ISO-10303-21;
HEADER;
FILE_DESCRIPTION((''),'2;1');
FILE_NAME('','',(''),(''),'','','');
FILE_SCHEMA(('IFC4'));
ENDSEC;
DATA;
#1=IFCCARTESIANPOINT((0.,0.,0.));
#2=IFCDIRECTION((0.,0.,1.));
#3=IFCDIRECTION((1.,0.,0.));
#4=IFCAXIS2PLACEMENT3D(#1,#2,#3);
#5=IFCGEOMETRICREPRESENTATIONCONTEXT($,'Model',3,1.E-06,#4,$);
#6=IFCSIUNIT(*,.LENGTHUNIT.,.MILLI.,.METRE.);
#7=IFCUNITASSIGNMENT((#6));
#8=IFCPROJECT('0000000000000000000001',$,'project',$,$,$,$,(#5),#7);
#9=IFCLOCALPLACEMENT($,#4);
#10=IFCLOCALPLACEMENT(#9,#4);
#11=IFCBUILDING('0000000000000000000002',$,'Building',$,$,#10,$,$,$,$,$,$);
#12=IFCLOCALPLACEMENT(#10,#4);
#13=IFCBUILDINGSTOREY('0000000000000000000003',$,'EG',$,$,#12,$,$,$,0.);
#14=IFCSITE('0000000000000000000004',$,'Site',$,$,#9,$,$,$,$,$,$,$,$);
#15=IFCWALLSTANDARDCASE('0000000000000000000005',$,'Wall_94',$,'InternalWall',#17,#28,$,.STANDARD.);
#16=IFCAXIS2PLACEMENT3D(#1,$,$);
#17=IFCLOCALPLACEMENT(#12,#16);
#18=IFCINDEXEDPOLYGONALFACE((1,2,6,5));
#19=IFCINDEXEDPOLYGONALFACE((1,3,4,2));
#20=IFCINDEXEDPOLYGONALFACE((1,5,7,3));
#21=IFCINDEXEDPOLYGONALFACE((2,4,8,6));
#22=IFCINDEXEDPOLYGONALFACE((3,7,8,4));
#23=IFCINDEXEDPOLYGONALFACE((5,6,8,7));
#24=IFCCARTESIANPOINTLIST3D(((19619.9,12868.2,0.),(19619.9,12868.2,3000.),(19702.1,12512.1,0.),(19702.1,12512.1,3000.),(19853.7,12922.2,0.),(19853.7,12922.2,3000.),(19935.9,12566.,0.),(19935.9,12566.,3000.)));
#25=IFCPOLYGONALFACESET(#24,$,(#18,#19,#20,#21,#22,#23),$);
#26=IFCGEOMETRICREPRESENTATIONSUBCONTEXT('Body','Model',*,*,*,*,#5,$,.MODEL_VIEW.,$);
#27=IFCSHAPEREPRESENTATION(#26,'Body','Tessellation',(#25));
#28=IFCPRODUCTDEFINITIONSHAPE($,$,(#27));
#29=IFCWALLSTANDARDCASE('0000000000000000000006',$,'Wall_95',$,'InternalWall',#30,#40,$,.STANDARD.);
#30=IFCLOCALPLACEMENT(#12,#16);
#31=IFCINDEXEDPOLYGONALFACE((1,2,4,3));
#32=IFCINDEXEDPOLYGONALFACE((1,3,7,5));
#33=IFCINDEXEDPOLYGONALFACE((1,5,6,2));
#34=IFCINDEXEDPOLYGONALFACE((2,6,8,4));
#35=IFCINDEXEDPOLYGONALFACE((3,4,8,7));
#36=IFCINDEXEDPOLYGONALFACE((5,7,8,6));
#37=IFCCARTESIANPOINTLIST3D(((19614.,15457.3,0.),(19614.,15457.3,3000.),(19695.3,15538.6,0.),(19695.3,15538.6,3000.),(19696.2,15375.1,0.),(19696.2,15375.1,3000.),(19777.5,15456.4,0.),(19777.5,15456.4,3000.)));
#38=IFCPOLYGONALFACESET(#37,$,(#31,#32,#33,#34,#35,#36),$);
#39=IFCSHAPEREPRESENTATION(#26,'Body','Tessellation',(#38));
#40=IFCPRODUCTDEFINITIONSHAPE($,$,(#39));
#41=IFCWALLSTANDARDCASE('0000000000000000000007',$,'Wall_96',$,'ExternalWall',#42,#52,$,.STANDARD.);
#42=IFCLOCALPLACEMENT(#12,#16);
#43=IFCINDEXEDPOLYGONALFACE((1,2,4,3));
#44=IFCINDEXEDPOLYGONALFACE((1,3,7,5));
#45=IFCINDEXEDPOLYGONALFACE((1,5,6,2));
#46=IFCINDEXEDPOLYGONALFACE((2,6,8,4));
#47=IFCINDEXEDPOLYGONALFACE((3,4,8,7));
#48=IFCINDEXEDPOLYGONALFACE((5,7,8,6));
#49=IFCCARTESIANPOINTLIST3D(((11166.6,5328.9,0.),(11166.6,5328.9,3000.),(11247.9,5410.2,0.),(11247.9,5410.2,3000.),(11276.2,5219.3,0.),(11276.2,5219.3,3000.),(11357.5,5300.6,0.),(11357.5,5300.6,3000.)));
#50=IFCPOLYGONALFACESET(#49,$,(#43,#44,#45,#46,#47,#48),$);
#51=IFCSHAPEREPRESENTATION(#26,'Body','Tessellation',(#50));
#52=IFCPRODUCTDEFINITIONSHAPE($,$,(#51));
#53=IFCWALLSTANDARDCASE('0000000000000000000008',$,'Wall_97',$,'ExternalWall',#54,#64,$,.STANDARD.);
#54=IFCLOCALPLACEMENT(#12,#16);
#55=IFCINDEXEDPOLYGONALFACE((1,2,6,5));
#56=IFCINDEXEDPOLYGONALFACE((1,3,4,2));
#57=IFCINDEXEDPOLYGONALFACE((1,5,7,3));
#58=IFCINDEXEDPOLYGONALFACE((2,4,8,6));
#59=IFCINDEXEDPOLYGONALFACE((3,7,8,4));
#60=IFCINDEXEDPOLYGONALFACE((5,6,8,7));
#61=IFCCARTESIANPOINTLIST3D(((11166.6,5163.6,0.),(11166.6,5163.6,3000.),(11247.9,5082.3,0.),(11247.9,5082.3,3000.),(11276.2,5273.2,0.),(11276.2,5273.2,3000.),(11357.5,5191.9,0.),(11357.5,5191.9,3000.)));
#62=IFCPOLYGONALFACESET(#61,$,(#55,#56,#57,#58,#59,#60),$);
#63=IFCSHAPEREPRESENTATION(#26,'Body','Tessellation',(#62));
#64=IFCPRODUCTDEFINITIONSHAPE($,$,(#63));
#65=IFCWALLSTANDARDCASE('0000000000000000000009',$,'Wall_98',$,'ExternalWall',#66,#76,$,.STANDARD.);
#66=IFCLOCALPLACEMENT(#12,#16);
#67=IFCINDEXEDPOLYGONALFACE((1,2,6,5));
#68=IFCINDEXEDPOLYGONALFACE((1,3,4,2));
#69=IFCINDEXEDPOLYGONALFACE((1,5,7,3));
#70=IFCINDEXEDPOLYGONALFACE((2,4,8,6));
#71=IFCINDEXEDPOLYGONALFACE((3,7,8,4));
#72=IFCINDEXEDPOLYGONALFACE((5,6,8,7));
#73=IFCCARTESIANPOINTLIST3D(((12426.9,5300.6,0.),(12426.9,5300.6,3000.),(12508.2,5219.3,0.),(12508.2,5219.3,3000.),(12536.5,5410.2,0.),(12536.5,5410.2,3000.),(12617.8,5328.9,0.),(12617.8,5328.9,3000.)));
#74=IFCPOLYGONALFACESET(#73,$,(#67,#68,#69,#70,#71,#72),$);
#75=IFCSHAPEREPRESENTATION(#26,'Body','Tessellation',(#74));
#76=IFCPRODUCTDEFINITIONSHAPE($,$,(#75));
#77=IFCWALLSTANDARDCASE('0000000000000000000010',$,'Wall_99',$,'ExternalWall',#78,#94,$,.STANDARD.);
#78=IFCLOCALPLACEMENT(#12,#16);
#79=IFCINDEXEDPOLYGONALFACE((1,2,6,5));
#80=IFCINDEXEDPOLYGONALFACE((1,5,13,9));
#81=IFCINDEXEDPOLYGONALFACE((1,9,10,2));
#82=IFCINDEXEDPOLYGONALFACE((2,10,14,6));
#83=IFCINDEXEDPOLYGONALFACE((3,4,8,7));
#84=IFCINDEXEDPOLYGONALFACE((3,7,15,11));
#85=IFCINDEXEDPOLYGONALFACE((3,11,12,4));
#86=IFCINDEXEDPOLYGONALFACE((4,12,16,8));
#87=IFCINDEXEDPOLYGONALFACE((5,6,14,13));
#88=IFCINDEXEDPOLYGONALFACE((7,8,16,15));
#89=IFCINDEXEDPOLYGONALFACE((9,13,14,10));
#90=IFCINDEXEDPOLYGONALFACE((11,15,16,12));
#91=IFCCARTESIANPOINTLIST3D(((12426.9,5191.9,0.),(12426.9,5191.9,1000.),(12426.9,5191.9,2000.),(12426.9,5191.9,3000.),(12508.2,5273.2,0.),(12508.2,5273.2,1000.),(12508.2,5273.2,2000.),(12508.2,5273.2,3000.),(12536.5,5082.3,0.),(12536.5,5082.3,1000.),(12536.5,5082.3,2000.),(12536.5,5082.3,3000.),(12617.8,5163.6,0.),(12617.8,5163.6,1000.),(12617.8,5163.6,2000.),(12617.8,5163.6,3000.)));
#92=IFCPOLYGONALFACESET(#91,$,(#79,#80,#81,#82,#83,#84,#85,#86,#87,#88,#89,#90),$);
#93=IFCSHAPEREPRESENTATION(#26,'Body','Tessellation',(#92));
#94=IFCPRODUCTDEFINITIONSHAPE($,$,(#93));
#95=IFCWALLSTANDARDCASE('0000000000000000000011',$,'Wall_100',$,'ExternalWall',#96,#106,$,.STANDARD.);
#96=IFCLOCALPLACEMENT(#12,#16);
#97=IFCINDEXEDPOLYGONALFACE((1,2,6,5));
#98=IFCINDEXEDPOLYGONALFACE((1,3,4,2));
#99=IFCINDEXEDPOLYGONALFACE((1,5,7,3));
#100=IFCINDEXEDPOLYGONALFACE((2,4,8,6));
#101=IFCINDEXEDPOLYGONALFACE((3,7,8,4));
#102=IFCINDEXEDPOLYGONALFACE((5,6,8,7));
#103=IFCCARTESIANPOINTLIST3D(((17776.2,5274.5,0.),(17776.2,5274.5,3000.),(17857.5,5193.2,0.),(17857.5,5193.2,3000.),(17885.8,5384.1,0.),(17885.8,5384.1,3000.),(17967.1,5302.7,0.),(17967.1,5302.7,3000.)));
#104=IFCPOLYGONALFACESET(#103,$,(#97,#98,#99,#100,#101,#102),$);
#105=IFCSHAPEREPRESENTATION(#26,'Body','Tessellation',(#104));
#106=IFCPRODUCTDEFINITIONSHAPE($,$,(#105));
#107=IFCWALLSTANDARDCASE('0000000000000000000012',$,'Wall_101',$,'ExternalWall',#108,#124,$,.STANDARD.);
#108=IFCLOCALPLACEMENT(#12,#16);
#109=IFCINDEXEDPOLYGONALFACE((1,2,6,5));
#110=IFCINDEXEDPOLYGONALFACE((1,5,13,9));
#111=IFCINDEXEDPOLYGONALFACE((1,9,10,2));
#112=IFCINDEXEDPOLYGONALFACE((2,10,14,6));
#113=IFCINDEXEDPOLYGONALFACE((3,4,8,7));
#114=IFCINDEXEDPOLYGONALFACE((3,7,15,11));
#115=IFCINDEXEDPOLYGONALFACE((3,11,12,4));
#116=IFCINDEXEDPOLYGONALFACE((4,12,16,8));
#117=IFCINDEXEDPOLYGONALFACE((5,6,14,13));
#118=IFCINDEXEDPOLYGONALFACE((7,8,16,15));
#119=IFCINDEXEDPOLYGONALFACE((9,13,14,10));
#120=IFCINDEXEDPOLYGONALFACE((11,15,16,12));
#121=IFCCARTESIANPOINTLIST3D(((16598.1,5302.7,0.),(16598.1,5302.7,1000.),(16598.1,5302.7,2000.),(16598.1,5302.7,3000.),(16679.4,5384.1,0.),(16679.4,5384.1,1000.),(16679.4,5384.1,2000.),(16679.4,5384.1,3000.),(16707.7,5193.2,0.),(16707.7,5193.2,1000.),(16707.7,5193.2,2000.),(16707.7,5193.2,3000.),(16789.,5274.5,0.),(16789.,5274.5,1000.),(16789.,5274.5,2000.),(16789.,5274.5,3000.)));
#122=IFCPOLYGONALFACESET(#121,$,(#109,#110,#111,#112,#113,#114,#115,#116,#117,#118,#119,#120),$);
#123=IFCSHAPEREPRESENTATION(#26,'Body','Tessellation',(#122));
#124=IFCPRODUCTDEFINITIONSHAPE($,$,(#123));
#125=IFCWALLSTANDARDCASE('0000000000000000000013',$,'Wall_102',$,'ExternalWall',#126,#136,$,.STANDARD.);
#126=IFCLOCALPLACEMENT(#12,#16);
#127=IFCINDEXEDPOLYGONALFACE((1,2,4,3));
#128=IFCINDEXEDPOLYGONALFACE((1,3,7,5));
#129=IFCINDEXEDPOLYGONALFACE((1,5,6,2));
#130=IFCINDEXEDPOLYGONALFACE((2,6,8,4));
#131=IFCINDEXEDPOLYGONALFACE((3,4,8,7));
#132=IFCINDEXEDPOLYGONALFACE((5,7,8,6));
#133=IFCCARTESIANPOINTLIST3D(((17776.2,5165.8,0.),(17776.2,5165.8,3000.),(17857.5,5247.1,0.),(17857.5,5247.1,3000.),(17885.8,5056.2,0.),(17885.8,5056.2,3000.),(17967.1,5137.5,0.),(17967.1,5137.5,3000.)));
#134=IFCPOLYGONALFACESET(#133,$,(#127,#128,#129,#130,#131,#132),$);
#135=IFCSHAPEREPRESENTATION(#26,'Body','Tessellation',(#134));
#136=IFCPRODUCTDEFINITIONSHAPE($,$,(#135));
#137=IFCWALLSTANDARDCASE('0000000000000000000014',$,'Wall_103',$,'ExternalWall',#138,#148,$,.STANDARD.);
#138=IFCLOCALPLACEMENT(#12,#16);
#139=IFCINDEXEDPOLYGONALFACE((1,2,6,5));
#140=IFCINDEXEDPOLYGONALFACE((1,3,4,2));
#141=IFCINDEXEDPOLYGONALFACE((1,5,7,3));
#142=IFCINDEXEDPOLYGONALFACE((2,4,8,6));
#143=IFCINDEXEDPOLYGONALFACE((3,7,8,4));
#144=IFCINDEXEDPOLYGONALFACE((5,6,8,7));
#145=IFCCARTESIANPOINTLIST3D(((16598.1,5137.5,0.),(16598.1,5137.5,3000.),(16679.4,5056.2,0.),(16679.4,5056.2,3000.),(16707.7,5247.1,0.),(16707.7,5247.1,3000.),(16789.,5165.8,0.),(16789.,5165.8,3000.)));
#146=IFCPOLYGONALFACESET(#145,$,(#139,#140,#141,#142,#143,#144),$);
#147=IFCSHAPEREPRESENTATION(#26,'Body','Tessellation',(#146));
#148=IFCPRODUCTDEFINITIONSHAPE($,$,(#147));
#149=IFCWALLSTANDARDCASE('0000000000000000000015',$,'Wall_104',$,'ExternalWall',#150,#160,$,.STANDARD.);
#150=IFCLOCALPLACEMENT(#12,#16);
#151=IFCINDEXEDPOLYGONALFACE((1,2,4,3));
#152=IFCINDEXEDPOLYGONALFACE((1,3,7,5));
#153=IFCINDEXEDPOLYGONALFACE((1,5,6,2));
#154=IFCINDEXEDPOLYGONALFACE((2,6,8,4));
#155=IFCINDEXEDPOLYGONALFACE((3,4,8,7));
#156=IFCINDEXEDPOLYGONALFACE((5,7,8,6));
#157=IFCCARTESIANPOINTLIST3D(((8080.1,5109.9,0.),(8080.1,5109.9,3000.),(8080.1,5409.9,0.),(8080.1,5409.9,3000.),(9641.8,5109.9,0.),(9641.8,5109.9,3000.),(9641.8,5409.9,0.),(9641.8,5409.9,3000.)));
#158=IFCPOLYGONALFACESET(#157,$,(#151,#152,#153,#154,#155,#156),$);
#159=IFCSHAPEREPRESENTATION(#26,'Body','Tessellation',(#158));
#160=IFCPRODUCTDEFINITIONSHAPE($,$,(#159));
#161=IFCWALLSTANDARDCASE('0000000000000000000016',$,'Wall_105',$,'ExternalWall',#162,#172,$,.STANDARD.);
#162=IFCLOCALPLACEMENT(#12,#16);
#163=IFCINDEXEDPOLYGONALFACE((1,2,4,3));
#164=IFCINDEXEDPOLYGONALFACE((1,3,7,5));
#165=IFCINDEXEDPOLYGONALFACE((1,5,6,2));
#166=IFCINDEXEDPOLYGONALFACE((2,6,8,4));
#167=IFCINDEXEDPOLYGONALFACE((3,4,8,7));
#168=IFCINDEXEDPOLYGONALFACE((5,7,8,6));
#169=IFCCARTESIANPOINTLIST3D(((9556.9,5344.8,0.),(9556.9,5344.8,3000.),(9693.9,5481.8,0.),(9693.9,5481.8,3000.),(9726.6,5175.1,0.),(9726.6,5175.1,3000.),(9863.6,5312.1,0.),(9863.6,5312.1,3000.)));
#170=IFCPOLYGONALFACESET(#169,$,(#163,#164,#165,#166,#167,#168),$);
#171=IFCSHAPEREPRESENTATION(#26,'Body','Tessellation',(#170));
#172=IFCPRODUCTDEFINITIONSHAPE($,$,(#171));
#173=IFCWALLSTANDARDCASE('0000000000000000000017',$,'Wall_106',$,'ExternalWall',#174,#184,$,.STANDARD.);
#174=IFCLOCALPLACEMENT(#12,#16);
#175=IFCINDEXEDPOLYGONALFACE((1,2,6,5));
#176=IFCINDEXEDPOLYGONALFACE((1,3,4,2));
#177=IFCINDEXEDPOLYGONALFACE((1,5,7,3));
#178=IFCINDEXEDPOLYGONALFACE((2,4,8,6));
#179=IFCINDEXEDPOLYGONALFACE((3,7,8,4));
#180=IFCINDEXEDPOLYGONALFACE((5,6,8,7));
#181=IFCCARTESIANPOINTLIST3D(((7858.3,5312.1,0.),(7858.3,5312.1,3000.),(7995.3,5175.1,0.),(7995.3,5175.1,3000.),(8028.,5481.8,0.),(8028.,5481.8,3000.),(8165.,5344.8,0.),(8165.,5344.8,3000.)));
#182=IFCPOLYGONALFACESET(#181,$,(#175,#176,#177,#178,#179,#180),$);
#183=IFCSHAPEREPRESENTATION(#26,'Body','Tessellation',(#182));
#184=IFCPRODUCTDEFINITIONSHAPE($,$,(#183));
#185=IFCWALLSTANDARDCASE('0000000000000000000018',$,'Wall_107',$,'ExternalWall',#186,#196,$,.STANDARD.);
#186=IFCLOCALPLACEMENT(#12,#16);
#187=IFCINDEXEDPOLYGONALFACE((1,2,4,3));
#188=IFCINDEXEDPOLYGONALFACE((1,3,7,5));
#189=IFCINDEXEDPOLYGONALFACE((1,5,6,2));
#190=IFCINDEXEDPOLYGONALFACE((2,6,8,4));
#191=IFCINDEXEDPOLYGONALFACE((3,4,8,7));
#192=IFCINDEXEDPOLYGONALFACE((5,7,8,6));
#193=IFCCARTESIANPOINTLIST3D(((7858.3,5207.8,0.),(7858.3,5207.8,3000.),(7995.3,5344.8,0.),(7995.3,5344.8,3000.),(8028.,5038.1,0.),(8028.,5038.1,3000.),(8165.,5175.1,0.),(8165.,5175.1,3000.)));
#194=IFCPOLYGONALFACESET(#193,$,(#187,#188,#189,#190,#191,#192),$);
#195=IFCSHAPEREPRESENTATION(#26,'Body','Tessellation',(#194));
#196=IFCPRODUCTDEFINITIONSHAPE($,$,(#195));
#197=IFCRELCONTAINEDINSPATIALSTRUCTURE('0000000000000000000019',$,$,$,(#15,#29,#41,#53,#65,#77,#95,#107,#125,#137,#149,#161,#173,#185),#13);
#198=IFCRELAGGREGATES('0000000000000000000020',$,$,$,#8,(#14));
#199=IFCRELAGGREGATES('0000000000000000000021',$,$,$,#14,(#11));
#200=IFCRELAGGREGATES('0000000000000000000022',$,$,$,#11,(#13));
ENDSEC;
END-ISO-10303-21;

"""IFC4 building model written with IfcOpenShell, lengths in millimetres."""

from ifc_helpers import new_model, si_unit, frame, origin_with_axes, place, context, subcontext, project, spatial, rectangle, extrude, element, save


model = new_model("IFC4")

# Units and contexts
model_context = context("Model", 3, precision=1e-06, world=origin_with_axes())
body_context = subcontext(model_context, "Body", "Model", "MODEL_VIEW")
ifc_project = project(units=[si_unit("LENGTHUNIT", "METRE", prefix="MILLI")], contexts=[model_context])

# Site, building, storey
site_placement = place(None, origin_with_axes())
site = spatial("IfcSite", under=ifc_project, at=site_placement, Name="Site")
building_placement = place(site_placement, origin_with_axes())
building = spatial("IfcBuilding", under=site, at=building_placement, Name="Building")
storey_placement = place(building_placement, origin_with_axes())
storey = spatial("IfcBuildingStorey", under=building, at=storey_placement, Name="EG", Elevation=0.0)

# Walls
wall_1_placement = place(storey_placement, origin_with_axes())
element("IfcWallStandardCase", 1, at=wall_1_placement, inside=storey, Name="Wall_94", ObjectType="InternalWall", PredefinedType="STANDARD", context=body_context, shape_type="SweptSolid", body=[
    extrude(rectangle(XDim=365.5, YDim=240.0), frame((19777.9, 12717.1, 0.0), z_axis=(0.0, 0.0, 1.0), x_axis=(0.22486, -0.974391, 0.0)), (0.0, 0.0, 1.0), 3000.0),
])
wall_2_placement = place(storey_placement, origin_with_axes())
element("IfcWallStandardCase", 2, at=wall_2_placement, inside=storey, Name="Wall_95", ObjectType="InternalWall", PredefinedType="STANDARD", context=body_context, shape_type="SweptSolid", body=[
    extrude(rectangle(XDim=116.2, YDim=115.0), frame((19695.7, 15456.9, 0.0), z_axis=(0.0, 0.0, 1.0), x_axis=(-0.707107, 0.707107, 0.0)), (0.0, 0.0, 1.0), 3000.0),
])
wall_3_placement = place(storey_placement, origin_with_axes())
element("IfcWallStandardCase", 3, at=wall_3_placement, inside=storey, Name="Wall_96", ObjectType="ExternalWall", PredefinedType="STANDARD", context=body_context, shape_type="SweptSolid", body=[
    extrude(rectangle(XDim=155.0, YDim=115.0), frame((11262.1, 5314.7, 0.0), z_axis=(0.0, 0.0, 1.0), x_axis=(-0.707107, 0.707107, 0.0)), (0.0, 0.0, 1.0), 3000.0),
])
wall_4_placement = place(storey_placement, origin_with_axes())
element("IfcWallStandardCase", 4, at=wall_4_placement, inside=storey, Name="Wall_97", ObjectType="ExternalWall", PredefinedType="STANDARD", context=body_context, shape_type="SweptSolid", body=[
    extrude(rectangle(XDim=155.0, YDim=115.0), frame((11262.1, 5177.7, 0.0), z_axis=(0.0, 0.0, 1.0), x_axis=(-0.707107, -0.707107, 0.0)), (0.0, 0.0, 1.0), 3000.0),
])
wall_5_placement = place(storey_placement, origin_with_axes())
element("IfcWallStandardCase", 5, at=wall_5_placement, inside=storey, Name="Wall_98", ObjectType="ExternalWall", PredefinedType="STANDARD", context=body_context, shape_type="SweptSolid", body=[
    extrude(rectangle(XDim=155.0, YDim=115.0), frame((12522.3, 5314.7, 0.0), z_axis=(0.0, 0.0, 1.0), x_axis=(0.707107, 0.707107, 0.0)), (0.0, 0.0, 1.0), 3000.0),
])

# Wall, opening
wall_6_placement = place(storey_placement, origin_with_axes())
wall_6 = element("IfcWallStandardCase", 6, at=wall_6_placement, inside=storey, Name="Wall_99", ObjectType="ExternalWall", PredefinedType="STANDARD", context=body_context, shape_type="SweptSolid", body=[
    extrude(rectangle(XDim=155.0, YDim=115.0), frame((12522.3, 5177.7, 0.0), z_axis=(0.0, 0.0, 1.0), x_axis=(0.707107, -0.707107, 0.0)), (0.0, 0.0, 1.0), 3000.0),
])
opening_1_placement = place(wall_6_placement, origin_with_axes())
element("IfcOpeningElement", 7, at=opening_1_placement, inside=storey, cuts=wall_6, context=body_context, shape_type="SweptSolid", body=[
    extrude(rectangle(XDim=1107.9, YDim=115.0), frame((12845.3, 4854.8, 1000.0), z_axis=(0.0, 0.0, 1.0), x_axis=(0.707107, -0.707107, 0.0)), (0.0, 0.0, 1.0), 1000.0),
])

# Wall
wall_7_placement = place(storey_placement, origin_with_axes())
element("IfcWallStandardCase", 8, at=wall_7_placement, inside=storey, Name="Wall_100", ObjectType="ExternalWall", PredefinedType="STANDARD", context=body_context, shape_type="SweptSolid", body=[
    extrude(rectangle(XDim=155.0, YDim=115.0), frame((17871.7, 5288.6, 0.0), z_axis=(0.0, 0.0, 1.0), x_axis=(0.707107, 0.707107, 0.0)), (0.0, 0.0, 1.0), 3000.0),
])

# Wall, opening
wall_8_placement = place(storey_placement, origin_with_axes())
wall_8 = element("IfcWallStandardCase", 9, at=wall_8_placement, inside=storey, Name="Wall_101", ObjectType="ExternalWall", PredefinedType="STANDARD", context=body_context, shape_type="SweptSolid", body=[
    extrude(rectangle(XDim=155.0, YDim=115.0), frame((16693.6, 5288.6, 0.0), z_axis=(0.0, 0.0, 1.0), x_axis=(-0.707107, 0.707107, 0.0)), (0.0, 0.0, 1.0), 3000.0),
])
opening_2_placement = place(wall_8_placement, origin_with_axes())
element("IfcOpeningElement", 10, at=opening_2_placement, inside=storey, cuts=wall_8, context=body_context, shape_type="SweptSolid", body=[
    extrude(rectangle(XDim=1126.3, YDim=115.0), frame((16350.8, 5631.4, 1000.0), z_axis=(0.0, 0.0, 1.0), x_axis=(-0.707107, 0.707107, 0.0)), (0.0, 0.0, 1.0), 1000.0),
])

# Walls
wall_9_placement = place(storey_placement, origin_with_axes())
element("IfcWallStandardCase", 11, at=wall_9_placement, inside=storey, Name="Wall_102", ObjectType="ExternalWall", PredefinedType="STANDARD", context=body_context, shape_type="SweptSolid", body=[
    extrude(rectangle(XDim=155.0, YDim=115.0), frame((17871.7, 5151.6, 0.0), z_axis=(0.0, 0.0, 1.0), x_axis=(0.707107, -0.707107, 0.0)), (0.0, 0.0, 1.0), 3000.0),
])
wall_10_placement = place(storey_placement, origin_with_axes())
element("IfcWallStandardCase", 12, at=wall_10_placement, inside=storey, Name="Wall_103", ObjectType="ExternalWall", PredefinedType="STANDARD", context=body_context, shape_type="SweptSolid", body=[
    extrude(rectangle(XDim=155.0, YDim=115.0), frame((16693.6, 5151.6, 0.0), z_axis=(0.0, 0.0, 1.0), x_axis=(-0.707107, -0.707107, 0.0)), (0.0, 0.0, 1.0), 3000.0),
])
wall_11_placement = place(storey_placement, origin_with_axes())
element("IfcWallStandardCase", 13, at=wall_11_placement, inside=storey, Name="Wall_104", ObjectType="ExternalWall", PredefinedType="STANDARD", context=body_context, shape_type="SweptSolid", body=[
    extrude(rectangle(XDim=1561.6, YDim=300.0), frame((8861.0, 5259.9, 0.0), z_axis=(0.0, 0.0, 1.0), x_axis=(-1.0, 0.0, 0.0)), (0.0, 0.0, 1.0), 3000.0),
])
wall_12_placement = place(storey_placement, origin_with_axes())
element("IfcWallStandardCase", 14, at=wall_12_placement, inside=storey, Name="Wall_105", ObjectType="ExternalWall", PredefinedType="STANDARD", context=body_context, shape_type="SweptSolid", body=[
    extrude(rectangle(XDim=193.7, YDim=240.0), frame((9710.3, 5328.4, 0.0), z_axis=(0.0, 0.0, 1.0), x_axis=(0.707107, 0.707107, 0.0)), (0.0, 0.0, 1.0), 3000.0),
])
wall_13_placement = place(storey_placement, origin_with_axes())
element("IfcWallStandardCase", 15, at=wall_13_placement, inside=storey, Name="Wall_106", ObjectType="ExternalWall", PredefinedType="STANDARD", context=body_context, shape_type="SweptSolid", body=[
    extrude(rectangle(XDim=193.7, YDim=240.0), frame((8011.6, 5328.4, 0.0), z_axis=(0.0, 0.0, 1.0), x_axis=(-0.707107, 0.707107, 0.0)), (0.0, 0.0, 1.0), 3000.0),
])
wall_14_placement = place(storey_placement, origin_with_axes())
element("IfcWallStandardCase", 16, at=wall_14_placement, inside=storey, Name="Wall_107", ObjectType="ExternalWall", PredefinedType="STANDARD", context=body_context, shape_type="SweptSolid", body=[
    extrude(rectangle(XDim=193.7, YDim=240.0), frame((8011.6, 5191.4, 0.0), z_axis=(0.0, 0.0, 1.0), x_axis=(-0.707107, -0.707107, 0.0)), (0.0, 0.0, 1.0), 3000.0),
])

save(model, "model.ifc")
